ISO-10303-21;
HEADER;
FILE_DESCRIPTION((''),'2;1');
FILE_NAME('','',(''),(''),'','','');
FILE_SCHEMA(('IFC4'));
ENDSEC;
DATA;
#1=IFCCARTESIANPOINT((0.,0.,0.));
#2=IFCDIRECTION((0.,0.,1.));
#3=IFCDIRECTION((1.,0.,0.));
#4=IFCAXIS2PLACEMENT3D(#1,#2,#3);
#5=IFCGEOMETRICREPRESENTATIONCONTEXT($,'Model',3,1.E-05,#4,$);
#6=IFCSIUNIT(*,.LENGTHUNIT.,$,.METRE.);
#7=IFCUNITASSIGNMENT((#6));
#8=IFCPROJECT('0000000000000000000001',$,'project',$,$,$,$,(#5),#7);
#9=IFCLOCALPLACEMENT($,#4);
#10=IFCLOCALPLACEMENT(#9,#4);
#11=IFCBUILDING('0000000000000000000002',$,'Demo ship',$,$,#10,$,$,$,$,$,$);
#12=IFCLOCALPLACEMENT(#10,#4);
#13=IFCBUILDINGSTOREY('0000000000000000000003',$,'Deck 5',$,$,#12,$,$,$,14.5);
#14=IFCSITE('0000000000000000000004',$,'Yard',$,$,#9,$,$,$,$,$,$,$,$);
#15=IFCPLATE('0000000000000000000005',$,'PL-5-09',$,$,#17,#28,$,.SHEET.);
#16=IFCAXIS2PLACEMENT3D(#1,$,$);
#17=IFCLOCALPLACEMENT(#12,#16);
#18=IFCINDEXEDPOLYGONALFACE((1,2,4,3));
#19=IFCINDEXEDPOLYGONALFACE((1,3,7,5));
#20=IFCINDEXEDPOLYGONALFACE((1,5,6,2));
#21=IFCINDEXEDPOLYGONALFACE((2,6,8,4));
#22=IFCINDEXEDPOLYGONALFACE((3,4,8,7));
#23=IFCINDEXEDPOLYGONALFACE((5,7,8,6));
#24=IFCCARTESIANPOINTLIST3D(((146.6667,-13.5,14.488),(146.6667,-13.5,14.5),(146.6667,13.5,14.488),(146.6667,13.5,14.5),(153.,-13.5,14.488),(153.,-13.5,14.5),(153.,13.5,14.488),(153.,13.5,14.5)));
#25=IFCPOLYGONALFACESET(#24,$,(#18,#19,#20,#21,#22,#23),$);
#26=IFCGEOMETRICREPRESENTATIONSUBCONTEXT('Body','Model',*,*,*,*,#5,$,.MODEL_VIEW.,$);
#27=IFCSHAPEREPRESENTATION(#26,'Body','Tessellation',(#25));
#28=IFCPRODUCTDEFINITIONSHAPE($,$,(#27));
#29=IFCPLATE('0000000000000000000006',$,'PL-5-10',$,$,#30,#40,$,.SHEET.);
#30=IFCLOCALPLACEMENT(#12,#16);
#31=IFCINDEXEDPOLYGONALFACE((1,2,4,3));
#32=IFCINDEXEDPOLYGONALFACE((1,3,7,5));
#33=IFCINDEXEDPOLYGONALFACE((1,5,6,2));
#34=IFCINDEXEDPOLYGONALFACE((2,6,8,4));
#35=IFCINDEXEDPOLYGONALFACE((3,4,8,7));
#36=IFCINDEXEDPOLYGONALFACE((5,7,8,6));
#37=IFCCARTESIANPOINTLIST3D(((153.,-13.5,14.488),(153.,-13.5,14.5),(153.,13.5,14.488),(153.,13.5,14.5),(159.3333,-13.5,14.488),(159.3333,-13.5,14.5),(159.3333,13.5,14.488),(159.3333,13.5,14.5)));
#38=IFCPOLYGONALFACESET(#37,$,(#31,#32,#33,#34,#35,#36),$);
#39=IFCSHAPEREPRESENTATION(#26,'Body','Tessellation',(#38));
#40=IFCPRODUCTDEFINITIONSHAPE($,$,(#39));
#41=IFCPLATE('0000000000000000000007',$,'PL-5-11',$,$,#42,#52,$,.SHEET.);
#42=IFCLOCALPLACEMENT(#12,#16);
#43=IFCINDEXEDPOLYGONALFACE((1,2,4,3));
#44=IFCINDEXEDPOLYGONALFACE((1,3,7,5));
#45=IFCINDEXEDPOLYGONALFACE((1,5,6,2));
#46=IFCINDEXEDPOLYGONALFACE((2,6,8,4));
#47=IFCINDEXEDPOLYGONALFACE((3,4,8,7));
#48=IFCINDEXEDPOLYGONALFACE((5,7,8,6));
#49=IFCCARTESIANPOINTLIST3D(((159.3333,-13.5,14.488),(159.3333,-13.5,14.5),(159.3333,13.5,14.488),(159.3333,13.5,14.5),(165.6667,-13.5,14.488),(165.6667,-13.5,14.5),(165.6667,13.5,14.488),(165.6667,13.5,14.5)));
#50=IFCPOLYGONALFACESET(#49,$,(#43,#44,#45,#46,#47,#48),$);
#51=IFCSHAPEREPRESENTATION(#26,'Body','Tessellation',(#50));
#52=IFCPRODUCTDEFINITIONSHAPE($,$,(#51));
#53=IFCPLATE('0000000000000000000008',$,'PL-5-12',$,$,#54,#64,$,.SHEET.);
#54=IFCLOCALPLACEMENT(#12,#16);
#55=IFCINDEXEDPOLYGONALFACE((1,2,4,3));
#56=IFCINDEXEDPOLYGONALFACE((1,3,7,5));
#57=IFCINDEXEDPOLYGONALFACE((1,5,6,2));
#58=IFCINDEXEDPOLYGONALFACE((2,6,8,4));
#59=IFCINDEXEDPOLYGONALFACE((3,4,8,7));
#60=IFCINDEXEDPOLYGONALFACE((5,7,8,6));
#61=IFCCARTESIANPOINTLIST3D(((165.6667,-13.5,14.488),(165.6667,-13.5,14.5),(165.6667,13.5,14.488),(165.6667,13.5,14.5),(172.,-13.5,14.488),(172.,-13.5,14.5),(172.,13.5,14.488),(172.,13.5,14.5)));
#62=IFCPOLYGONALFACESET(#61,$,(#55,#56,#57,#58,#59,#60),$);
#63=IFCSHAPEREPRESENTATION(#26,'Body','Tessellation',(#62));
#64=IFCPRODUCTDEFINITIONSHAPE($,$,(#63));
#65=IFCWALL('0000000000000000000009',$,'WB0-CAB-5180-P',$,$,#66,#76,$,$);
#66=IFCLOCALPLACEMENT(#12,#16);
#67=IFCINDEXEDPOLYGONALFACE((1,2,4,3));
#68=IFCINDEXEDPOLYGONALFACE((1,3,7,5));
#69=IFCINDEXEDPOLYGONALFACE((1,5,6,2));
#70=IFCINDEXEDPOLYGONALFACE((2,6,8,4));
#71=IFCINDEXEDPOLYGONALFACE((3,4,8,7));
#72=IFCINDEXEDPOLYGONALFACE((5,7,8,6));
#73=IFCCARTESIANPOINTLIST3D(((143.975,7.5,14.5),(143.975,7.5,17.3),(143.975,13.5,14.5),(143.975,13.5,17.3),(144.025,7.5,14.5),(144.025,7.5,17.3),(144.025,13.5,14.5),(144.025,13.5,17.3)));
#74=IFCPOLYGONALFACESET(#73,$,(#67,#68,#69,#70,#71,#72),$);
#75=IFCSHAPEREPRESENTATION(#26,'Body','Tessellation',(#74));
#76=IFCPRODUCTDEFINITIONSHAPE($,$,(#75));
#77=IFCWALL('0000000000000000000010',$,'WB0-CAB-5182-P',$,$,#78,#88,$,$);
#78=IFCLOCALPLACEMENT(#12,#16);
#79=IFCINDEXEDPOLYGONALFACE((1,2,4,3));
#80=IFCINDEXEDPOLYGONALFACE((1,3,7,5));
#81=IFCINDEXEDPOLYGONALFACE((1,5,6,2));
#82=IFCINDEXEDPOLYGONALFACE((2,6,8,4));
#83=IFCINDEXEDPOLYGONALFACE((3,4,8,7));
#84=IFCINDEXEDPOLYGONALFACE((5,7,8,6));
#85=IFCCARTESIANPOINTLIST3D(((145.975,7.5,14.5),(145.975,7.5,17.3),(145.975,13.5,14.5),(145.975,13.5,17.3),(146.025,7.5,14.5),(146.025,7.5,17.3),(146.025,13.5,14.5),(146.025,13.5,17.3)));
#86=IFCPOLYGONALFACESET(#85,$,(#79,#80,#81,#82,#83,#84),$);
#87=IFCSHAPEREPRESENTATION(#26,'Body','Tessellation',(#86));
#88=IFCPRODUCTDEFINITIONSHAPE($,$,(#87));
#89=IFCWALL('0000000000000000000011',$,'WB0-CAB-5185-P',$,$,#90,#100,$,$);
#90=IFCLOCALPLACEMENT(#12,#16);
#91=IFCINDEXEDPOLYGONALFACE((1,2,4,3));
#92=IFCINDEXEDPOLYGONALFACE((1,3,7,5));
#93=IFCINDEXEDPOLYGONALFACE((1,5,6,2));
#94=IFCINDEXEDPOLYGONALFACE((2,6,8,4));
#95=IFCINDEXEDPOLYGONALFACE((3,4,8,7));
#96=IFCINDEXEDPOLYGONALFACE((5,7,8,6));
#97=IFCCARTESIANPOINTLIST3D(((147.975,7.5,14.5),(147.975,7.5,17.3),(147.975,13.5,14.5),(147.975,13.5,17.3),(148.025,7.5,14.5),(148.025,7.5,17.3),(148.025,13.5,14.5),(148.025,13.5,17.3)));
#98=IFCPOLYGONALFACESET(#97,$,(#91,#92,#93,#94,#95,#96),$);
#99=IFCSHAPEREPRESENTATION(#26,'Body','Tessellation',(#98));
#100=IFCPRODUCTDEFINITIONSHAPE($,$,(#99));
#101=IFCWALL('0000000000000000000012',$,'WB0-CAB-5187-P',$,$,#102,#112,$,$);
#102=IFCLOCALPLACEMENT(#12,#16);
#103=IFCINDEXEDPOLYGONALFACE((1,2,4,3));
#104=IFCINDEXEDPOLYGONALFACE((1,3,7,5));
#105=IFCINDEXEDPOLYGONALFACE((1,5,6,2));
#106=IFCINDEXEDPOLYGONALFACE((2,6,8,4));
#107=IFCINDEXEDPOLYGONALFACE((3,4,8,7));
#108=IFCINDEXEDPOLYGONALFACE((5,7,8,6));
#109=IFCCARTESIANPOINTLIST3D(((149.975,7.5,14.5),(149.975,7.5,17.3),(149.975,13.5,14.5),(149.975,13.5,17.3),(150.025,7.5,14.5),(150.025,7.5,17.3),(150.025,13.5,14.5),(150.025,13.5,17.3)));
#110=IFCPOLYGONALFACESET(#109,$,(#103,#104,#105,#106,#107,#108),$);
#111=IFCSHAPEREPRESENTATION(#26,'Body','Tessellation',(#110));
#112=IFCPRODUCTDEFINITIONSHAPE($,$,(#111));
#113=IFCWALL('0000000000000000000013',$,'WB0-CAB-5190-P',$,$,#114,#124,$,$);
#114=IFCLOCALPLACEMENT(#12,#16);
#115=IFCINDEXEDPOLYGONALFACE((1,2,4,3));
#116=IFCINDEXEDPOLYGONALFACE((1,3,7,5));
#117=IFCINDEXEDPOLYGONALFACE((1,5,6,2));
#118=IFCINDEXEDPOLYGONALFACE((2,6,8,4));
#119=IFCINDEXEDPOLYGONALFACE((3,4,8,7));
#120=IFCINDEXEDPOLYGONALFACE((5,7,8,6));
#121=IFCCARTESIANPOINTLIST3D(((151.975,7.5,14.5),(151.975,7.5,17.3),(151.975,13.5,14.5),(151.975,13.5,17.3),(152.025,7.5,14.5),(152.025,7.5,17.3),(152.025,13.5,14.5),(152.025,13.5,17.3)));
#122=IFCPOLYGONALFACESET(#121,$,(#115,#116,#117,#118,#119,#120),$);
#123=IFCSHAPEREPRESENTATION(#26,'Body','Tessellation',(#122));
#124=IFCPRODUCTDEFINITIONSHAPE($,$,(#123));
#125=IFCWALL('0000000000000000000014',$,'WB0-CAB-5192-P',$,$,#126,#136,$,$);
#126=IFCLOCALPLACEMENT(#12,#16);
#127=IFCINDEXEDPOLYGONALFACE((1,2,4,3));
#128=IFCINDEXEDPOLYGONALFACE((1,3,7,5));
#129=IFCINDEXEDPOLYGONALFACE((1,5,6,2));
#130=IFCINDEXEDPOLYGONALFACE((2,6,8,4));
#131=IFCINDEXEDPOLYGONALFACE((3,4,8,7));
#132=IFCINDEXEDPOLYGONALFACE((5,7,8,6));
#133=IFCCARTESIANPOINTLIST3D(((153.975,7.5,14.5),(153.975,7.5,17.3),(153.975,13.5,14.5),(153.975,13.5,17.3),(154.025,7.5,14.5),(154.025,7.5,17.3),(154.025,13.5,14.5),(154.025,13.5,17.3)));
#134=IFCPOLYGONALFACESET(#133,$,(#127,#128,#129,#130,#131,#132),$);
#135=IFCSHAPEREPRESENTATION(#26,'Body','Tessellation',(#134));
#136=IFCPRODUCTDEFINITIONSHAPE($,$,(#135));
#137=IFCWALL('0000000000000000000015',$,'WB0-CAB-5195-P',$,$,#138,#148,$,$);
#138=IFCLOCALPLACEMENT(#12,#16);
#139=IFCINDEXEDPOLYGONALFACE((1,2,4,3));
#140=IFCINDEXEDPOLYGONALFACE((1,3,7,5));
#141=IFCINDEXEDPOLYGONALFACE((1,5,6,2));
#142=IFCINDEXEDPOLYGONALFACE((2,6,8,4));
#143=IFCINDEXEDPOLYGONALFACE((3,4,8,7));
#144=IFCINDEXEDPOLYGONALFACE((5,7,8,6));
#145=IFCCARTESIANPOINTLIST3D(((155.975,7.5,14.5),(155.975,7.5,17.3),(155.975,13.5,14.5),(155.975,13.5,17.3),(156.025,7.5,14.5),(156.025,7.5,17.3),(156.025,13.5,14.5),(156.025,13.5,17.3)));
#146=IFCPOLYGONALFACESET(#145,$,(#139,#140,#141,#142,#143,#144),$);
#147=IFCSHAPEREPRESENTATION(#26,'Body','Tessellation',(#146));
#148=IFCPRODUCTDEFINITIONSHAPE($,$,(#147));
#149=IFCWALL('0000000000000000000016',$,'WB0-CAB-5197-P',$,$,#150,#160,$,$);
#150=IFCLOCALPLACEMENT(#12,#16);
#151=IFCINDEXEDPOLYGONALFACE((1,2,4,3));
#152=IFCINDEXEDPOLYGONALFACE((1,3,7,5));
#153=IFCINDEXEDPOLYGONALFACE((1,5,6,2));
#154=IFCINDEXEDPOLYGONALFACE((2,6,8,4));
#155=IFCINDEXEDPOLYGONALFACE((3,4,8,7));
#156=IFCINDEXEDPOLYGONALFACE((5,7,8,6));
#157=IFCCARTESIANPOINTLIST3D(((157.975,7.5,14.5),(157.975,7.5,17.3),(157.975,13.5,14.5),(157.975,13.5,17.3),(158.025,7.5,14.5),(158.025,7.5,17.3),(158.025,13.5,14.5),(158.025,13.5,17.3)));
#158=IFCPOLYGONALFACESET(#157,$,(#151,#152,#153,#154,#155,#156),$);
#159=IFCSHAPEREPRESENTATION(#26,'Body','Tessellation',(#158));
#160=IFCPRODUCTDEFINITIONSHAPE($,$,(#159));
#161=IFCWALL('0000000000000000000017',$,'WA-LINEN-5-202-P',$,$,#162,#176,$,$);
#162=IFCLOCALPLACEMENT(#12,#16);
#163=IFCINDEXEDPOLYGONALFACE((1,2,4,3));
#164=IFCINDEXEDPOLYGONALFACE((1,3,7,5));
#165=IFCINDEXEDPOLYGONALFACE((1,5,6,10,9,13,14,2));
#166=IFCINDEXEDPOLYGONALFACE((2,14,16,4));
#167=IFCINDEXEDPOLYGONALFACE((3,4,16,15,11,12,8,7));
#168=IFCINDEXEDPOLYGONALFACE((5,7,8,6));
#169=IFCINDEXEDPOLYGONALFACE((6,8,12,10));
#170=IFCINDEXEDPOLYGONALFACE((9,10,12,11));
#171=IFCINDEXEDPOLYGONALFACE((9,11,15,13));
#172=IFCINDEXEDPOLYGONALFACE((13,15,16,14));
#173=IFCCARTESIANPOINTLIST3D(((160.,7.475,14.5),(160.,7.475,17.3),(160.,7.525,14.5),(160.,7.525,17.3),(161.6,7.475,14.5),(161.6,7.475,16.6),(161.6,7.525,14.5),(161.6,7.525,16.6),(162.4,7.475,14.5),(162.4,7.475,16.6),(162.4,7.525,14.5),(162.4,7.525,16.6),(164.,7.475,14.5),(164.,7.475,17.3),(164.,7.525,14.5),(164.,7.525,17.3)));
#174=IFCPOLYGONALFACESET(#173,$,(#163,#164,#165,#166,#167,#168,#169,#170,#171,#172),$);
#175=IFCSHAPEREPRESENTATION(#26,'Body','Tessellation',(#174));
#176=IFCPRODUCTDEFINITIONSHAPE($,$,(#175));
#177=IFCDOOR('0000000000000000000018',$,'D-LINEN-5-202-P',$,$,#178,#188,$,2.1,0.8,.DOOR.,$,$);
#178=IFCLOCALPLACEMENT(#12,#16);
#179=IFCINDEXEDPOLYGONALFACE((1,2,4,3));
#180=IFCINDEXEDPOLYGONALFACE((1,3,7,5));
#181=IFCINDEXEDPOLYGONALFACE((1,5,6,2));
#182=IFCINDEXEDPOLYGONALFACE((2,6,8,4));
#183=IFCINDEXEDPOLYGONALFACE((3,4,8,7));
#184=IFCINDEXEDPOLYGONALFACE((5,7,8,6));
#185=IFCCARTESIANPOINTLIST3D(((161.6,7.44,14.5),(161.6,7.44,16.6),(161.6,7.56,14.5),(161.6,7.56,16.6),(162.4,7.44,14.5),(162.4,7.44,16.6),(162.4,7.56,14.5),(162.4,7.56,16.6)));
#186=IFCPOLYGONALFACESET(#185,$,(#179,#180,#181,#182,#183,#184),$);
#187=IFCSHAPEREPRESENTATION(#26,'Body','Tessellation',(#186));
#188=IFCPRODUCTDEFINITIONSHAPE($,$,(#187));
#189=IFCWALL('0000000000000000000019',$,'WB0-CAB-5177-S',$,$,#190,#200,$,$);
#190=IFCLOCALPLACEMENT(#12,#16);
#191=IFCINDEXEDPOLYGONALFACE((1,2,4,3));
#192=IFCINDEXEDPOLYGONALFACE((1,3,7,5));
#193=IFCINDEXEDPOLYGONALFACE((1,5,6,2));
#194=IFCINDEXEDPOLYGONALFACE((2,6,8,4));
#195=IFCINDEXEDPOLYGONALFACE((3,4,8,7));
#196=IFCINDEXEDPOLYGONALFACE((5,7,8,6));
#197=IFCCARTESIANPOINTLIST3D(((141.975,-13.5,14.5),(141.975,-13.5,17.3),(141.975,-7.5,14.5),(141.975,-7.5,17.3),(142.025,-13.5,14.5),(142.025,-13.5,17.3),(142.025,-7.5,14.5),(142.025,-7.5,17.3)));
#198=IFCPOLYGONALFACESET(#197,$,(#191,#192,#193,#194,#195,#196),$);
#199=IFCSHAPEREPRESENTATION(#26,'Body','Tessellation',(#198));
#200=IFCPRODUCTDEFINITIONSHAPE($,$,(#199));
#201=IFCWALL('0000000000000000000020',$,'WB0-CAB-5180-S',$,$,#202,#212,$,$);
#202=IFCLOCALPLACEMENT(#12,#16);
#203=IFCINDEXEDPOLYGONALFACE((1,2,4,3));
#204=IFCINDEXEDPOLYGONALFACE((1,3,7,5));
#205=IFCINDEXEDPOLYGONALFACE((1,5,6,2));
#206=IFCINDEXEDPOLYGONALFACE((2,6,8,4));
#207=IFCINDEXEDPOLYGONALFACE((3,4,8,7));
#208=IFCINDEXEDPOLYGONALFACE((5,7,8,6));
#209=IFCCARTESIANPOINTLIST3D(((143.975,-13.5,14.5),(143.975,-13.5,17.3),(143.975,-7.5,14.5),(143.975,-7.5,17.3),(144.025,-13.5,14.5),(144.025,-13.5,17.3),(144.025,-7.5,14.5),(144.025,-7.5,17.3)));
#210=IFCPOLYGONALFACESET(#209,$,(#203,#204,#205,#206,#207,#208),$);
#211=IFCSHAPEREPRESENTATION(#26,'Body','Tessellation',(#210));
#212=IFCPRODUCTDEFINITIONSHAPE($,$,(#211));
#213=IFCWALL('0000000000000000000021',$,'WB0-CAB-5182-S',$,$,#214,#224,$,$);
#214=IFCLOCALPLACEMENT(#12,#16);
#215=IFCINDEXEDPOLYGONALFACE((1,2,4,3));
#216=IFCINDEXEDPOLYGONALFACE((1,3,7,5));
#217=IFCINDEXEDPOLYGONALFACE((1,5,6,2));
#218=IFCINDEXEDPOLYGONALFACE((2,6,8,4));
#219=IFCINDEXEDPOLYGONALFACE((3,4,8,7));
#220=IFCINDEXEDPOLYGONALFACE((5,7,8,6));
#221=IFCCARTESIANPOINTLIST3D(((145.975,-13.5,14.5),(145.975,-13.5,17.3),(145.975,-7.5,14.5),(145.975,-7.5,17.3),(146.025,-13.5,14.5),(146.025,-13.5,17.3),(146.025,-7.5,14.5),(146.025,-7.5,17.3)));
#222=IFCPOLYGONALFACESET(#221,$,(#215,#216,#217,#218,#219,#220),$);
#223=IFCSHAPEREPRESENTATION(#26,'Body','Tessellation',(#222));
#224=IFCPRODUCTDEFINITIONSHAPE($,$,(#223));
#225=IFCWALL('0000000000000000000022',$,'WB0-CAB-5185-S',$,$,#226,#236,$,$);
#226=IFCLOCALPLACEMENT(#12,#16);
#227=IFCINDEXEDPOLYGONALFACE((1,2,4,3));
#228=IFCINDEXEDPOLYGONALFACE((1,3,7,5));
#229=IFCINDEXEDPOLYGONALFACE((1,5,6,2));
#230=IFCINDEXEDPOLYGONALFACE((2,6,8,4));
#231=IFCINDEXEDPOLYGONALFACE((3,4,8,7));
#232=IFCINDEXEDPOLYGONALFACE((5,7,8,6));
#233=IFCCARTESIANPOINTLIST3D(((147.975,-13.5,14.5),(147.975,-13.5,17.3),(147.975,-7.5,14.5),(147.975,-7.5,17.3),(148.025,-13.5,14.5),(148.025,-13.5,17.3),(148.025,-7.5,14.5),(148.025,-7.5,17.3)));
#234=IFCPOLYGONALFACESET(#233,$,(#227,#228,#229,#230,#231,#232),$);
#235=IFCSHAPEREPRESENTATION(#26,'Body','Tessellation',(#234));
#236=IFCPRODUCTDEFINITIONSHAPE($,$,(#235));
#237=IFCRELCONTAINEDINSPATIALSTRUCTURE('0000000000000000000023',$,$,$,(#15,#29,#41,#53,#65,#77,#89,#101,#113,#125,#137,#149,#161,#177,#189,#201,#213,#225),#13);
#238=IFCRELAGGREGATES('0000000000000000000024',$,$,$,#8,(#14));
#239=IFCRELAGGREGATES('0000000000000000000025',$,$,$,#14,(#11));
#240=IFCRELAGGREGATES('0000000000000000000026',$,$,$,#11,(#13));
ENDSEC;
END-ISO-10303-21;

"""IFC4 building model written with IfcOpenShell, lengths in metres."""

from ifc_helpers import new_model, si_unit, frame, frame_2d, origin, origin_with_axes, place, context, subcontext, project, spatial, rectangle, extrude, element, fill, save


model = new_model("IFC4")

# Units and contexts
model_context = context("Model", 3, precision=1e-05, world=origin_with_axes())
body_context = subcontext(model_context, "Body", "Model", "MODEL_VIEW")
ifc_project = project(units=[si_unit("LENGTHUNIT", "METRE")], contexts=[model_context])

# Site, building, storey
site_placement = place(None, origin_with_axes())
site = spatial("IfcSite", under=ifc_project, at=site_placement, Name="Yard")
building_placement = place(site_placement, origin_with_axes())
building = spatial("IfcBuilding", under=site, at=building_placement, Name="Demo ship")
storey_placement = place(building_placement, origin_with_axes())
storey = spatial("IfcBuildingStorey", under=building, at=storey_placement, Name="Deck 5", Elevation=14.5)

# Plates
for number, where, z_axis, x_axis, name in (
    (1, (146.6667, -13.5, 14.488), (0.0, 0.0, 1.0), (1.0, 0.0, 0.0), "PL-5-09"),
    (2, (153.0, -13.5, 14.488), (0.0, 0.0, 1.0), (1.0, 0.0, 0.0), "PL-5-10"),
):
    element("IfcPlate", number, at=place(storey_placement, frame(where, z_axis=z_axis, x_axis=x_axis)), inside=storey, Name=name, PredefinedType="SHEET", context=body_context, shape_type="SweptSolid", body=[
        extrude(rectangle(XDim=6.3333, YDim=27.0, at=frame_2d((3.1667, 13.5))), origin(), (0.0, 0.0, 1.0), 0.012),
    ])
plate_1_placement = place(storey_placement, frame((159.3333, -13.5, 14.488), z_axis=(0.0, 0.0, 1.0), x_axis=(1.0, 0.0, 0.0)))
element("IfcPlate", 3, at=plate_1_placement, inside=storey, Name="PL-5-11", PredefinedType="SHEET", context=body_context, shape_type="SweptSolid", body=[
    extrude(rectangle(XDim=6.3334, YDim=27.0, at=frame_2d((3.1667, 13.5))), origin(), (0.0, 0.0, 1.0), 0.012),
])
plate_2_placement = place(storey_placement, frame((165.6667, -13.5, 14.488), z_axis=(0.0, 0.0, 1.0), x_axis=(1.0, 0.0, 0.0)))
element("IfcPlate", 4, at=plate_2_placement, inside=storey, Name="PL-5-12", PredefinedType="SHEET", context=body_context, shape_type="SweptSolid", body=[
    extrude(rectangle(XDim=6.3333, YDim=27.0, at=frame_2d((3.1667, 13.5))), origin(), (0.0, 0.0, 1.0), 0.012),
])

# Walls
for number, where, z_axis, x_axis, name in (
    (5, (143.975, 7.5, 14.5), (0.0, 0.0, 1.0), (1.0, 0.0, 0.0), "WB0-CAB-5180-P"),
    (6, (145.975, 7.5, 14.5), (0.0, 0.0, 1.0), (1.0, 0.0, 0.0), "WB0-CAB-5182-P"),
    (7, (147.975, 7.5, 14.5), (0.0, 0.0, 1.0), (1.0, 0.0, 0.0), "WB0-CAB-5185-P"),
    (8, (149.975, 7.5, 14.5), (0.0, 0.0, 1.0), (1.0, 0.0, 0.0), "WB0-CAB-5187-P"),
    (9, (151.975, 7.5, 14.5), (0.0, 0.0, 1.0), (1.0, 0.0, 0.0), "WB0-CAB-5190-P"),
    (10, (153.975, 7.5, 14.5), (0.0, 0.0, 1.0), (1.0, 0.0, 0.0), "WB0-CAB-5192-P"),
    (11, (155.975, 7.5, 14.5), (0.0, 0.0, 1.0), (1.0, 0.0, 0.0), "WB0-CAB-5195-P"),
    (12, (157.975, 7.5, 14.5), (0.0, 0.0, 1.0), (1.0, 0.0, 0.0), "WB0-CAB-5197-P"),
):
    element("IfcWall", number, at=place(storey_placement, frame(where, z_axis=z_axis, x_axis=x_axis)), inside=storey, Name=name, context=body_context, shape_type="SweptSolid", body=[
        extrude(rectangle(XDim=0.05, YDim=6.0, at=frame_2d((0.025, 3.0))), origin(), (0.0, 0.0, 1.0), 2.8),
    ])

# Wall, opening, door
wall_1_placement = place(storey_placement, frame((160.0, 7.475, 14.5), z_axis=(0.0, 0.0, 1.0), x_axis=(1.0, 0.0, 0.0)))
wall_1 = element("IfcWall", 13, at=wall_1_placement, inside=storey, Name="WA-LINEN-5-202-P", context=body_context, shape_type="SweptSolid", body=[
    extrude(rectangle(XDim=4.0, YDim=0.05, at=frame_2d((2.0, 0.025))), origin(), (0.0, 0.0, 1.0), 2.8),
])
opening_1_placement = place(None, frame((161.6, 7.44, 14.5), z_axis=(0.0, 0.0, 1.0), x_axis=(1.0, 0.0, 0.0)))
opening_1 = element("IfcOpeningElement", 14, at=opening_1_placement, cuts=wall_1, context=body_context, shape_type="SweptSolid", body=[
    extrude(rectangle(XDim=0.8, YDim=0.12, at=frame_2d((0.4, 0.06))), origin(), (0.0, 0.0, 1.0), 2.1),
])
door_1_placement = place(storey_placement, frame((161.6, 7.44, 14.5), z_axis=(0.0, 0.0, 1.0), x_axis=(1.0, 0.0, 0.0)))
door_1 = element("IfcDoor", 15, at=door_1_placement, inside=storey, Name="D-LINEN-5-202-P", OverallHeight=2.1, OverallWidth=0.8, PredefinedType="DOOR", context=body_context, shape_type="SweptSolid", body=[
    extrude(rectangle(XDim=0.8, YDim=0.12, at=frame_2d((0.4, 0.06))), origin(), (0.0, 0.0, 1.0), 2.1),
])
fill(opening_1, door_1)

# Walls
for number, where, z_axis, x_axis, name in (
    (16, (141.975, -13.5, 14.5), (0.0, 0.0, 1.0), (1.0, 0.0, 0.0), "WB0-CAB-5177-S"),
    (17, (143.975, -13.5, 14.5), (0.0, 0.0, 1.0), (1.0, 0.0, 0.0), "WB0-CAB-5180-S"),
    (18, (145.975, -13.5, 14.5), (0.0, 0.0, 1.0), (1.0, 0.0, 0.0), "WB0-CAB-5182-S"),
    (19, (147.975, -13.5, 14.5), (0.0, 0.0, 1.0), (1.0, 0.0, 0.0), "WB0-CAB-5185-S"),
):
    element("IfcWall", number, at=place(storey_placement, frame(where, z_axis=z_axis, x_axis=x_axis)), inside=storey, Name=name, context=body_context, shape_type="SweptSolid", body=[
        extrude(rectangle(XDim=0.05, YDim=6.0, at=frame_2d((0.025, 3.0))), origin(), (0.0, 0.0, 1.0), 2.8),
    ])

save(model, "model.ifc")
